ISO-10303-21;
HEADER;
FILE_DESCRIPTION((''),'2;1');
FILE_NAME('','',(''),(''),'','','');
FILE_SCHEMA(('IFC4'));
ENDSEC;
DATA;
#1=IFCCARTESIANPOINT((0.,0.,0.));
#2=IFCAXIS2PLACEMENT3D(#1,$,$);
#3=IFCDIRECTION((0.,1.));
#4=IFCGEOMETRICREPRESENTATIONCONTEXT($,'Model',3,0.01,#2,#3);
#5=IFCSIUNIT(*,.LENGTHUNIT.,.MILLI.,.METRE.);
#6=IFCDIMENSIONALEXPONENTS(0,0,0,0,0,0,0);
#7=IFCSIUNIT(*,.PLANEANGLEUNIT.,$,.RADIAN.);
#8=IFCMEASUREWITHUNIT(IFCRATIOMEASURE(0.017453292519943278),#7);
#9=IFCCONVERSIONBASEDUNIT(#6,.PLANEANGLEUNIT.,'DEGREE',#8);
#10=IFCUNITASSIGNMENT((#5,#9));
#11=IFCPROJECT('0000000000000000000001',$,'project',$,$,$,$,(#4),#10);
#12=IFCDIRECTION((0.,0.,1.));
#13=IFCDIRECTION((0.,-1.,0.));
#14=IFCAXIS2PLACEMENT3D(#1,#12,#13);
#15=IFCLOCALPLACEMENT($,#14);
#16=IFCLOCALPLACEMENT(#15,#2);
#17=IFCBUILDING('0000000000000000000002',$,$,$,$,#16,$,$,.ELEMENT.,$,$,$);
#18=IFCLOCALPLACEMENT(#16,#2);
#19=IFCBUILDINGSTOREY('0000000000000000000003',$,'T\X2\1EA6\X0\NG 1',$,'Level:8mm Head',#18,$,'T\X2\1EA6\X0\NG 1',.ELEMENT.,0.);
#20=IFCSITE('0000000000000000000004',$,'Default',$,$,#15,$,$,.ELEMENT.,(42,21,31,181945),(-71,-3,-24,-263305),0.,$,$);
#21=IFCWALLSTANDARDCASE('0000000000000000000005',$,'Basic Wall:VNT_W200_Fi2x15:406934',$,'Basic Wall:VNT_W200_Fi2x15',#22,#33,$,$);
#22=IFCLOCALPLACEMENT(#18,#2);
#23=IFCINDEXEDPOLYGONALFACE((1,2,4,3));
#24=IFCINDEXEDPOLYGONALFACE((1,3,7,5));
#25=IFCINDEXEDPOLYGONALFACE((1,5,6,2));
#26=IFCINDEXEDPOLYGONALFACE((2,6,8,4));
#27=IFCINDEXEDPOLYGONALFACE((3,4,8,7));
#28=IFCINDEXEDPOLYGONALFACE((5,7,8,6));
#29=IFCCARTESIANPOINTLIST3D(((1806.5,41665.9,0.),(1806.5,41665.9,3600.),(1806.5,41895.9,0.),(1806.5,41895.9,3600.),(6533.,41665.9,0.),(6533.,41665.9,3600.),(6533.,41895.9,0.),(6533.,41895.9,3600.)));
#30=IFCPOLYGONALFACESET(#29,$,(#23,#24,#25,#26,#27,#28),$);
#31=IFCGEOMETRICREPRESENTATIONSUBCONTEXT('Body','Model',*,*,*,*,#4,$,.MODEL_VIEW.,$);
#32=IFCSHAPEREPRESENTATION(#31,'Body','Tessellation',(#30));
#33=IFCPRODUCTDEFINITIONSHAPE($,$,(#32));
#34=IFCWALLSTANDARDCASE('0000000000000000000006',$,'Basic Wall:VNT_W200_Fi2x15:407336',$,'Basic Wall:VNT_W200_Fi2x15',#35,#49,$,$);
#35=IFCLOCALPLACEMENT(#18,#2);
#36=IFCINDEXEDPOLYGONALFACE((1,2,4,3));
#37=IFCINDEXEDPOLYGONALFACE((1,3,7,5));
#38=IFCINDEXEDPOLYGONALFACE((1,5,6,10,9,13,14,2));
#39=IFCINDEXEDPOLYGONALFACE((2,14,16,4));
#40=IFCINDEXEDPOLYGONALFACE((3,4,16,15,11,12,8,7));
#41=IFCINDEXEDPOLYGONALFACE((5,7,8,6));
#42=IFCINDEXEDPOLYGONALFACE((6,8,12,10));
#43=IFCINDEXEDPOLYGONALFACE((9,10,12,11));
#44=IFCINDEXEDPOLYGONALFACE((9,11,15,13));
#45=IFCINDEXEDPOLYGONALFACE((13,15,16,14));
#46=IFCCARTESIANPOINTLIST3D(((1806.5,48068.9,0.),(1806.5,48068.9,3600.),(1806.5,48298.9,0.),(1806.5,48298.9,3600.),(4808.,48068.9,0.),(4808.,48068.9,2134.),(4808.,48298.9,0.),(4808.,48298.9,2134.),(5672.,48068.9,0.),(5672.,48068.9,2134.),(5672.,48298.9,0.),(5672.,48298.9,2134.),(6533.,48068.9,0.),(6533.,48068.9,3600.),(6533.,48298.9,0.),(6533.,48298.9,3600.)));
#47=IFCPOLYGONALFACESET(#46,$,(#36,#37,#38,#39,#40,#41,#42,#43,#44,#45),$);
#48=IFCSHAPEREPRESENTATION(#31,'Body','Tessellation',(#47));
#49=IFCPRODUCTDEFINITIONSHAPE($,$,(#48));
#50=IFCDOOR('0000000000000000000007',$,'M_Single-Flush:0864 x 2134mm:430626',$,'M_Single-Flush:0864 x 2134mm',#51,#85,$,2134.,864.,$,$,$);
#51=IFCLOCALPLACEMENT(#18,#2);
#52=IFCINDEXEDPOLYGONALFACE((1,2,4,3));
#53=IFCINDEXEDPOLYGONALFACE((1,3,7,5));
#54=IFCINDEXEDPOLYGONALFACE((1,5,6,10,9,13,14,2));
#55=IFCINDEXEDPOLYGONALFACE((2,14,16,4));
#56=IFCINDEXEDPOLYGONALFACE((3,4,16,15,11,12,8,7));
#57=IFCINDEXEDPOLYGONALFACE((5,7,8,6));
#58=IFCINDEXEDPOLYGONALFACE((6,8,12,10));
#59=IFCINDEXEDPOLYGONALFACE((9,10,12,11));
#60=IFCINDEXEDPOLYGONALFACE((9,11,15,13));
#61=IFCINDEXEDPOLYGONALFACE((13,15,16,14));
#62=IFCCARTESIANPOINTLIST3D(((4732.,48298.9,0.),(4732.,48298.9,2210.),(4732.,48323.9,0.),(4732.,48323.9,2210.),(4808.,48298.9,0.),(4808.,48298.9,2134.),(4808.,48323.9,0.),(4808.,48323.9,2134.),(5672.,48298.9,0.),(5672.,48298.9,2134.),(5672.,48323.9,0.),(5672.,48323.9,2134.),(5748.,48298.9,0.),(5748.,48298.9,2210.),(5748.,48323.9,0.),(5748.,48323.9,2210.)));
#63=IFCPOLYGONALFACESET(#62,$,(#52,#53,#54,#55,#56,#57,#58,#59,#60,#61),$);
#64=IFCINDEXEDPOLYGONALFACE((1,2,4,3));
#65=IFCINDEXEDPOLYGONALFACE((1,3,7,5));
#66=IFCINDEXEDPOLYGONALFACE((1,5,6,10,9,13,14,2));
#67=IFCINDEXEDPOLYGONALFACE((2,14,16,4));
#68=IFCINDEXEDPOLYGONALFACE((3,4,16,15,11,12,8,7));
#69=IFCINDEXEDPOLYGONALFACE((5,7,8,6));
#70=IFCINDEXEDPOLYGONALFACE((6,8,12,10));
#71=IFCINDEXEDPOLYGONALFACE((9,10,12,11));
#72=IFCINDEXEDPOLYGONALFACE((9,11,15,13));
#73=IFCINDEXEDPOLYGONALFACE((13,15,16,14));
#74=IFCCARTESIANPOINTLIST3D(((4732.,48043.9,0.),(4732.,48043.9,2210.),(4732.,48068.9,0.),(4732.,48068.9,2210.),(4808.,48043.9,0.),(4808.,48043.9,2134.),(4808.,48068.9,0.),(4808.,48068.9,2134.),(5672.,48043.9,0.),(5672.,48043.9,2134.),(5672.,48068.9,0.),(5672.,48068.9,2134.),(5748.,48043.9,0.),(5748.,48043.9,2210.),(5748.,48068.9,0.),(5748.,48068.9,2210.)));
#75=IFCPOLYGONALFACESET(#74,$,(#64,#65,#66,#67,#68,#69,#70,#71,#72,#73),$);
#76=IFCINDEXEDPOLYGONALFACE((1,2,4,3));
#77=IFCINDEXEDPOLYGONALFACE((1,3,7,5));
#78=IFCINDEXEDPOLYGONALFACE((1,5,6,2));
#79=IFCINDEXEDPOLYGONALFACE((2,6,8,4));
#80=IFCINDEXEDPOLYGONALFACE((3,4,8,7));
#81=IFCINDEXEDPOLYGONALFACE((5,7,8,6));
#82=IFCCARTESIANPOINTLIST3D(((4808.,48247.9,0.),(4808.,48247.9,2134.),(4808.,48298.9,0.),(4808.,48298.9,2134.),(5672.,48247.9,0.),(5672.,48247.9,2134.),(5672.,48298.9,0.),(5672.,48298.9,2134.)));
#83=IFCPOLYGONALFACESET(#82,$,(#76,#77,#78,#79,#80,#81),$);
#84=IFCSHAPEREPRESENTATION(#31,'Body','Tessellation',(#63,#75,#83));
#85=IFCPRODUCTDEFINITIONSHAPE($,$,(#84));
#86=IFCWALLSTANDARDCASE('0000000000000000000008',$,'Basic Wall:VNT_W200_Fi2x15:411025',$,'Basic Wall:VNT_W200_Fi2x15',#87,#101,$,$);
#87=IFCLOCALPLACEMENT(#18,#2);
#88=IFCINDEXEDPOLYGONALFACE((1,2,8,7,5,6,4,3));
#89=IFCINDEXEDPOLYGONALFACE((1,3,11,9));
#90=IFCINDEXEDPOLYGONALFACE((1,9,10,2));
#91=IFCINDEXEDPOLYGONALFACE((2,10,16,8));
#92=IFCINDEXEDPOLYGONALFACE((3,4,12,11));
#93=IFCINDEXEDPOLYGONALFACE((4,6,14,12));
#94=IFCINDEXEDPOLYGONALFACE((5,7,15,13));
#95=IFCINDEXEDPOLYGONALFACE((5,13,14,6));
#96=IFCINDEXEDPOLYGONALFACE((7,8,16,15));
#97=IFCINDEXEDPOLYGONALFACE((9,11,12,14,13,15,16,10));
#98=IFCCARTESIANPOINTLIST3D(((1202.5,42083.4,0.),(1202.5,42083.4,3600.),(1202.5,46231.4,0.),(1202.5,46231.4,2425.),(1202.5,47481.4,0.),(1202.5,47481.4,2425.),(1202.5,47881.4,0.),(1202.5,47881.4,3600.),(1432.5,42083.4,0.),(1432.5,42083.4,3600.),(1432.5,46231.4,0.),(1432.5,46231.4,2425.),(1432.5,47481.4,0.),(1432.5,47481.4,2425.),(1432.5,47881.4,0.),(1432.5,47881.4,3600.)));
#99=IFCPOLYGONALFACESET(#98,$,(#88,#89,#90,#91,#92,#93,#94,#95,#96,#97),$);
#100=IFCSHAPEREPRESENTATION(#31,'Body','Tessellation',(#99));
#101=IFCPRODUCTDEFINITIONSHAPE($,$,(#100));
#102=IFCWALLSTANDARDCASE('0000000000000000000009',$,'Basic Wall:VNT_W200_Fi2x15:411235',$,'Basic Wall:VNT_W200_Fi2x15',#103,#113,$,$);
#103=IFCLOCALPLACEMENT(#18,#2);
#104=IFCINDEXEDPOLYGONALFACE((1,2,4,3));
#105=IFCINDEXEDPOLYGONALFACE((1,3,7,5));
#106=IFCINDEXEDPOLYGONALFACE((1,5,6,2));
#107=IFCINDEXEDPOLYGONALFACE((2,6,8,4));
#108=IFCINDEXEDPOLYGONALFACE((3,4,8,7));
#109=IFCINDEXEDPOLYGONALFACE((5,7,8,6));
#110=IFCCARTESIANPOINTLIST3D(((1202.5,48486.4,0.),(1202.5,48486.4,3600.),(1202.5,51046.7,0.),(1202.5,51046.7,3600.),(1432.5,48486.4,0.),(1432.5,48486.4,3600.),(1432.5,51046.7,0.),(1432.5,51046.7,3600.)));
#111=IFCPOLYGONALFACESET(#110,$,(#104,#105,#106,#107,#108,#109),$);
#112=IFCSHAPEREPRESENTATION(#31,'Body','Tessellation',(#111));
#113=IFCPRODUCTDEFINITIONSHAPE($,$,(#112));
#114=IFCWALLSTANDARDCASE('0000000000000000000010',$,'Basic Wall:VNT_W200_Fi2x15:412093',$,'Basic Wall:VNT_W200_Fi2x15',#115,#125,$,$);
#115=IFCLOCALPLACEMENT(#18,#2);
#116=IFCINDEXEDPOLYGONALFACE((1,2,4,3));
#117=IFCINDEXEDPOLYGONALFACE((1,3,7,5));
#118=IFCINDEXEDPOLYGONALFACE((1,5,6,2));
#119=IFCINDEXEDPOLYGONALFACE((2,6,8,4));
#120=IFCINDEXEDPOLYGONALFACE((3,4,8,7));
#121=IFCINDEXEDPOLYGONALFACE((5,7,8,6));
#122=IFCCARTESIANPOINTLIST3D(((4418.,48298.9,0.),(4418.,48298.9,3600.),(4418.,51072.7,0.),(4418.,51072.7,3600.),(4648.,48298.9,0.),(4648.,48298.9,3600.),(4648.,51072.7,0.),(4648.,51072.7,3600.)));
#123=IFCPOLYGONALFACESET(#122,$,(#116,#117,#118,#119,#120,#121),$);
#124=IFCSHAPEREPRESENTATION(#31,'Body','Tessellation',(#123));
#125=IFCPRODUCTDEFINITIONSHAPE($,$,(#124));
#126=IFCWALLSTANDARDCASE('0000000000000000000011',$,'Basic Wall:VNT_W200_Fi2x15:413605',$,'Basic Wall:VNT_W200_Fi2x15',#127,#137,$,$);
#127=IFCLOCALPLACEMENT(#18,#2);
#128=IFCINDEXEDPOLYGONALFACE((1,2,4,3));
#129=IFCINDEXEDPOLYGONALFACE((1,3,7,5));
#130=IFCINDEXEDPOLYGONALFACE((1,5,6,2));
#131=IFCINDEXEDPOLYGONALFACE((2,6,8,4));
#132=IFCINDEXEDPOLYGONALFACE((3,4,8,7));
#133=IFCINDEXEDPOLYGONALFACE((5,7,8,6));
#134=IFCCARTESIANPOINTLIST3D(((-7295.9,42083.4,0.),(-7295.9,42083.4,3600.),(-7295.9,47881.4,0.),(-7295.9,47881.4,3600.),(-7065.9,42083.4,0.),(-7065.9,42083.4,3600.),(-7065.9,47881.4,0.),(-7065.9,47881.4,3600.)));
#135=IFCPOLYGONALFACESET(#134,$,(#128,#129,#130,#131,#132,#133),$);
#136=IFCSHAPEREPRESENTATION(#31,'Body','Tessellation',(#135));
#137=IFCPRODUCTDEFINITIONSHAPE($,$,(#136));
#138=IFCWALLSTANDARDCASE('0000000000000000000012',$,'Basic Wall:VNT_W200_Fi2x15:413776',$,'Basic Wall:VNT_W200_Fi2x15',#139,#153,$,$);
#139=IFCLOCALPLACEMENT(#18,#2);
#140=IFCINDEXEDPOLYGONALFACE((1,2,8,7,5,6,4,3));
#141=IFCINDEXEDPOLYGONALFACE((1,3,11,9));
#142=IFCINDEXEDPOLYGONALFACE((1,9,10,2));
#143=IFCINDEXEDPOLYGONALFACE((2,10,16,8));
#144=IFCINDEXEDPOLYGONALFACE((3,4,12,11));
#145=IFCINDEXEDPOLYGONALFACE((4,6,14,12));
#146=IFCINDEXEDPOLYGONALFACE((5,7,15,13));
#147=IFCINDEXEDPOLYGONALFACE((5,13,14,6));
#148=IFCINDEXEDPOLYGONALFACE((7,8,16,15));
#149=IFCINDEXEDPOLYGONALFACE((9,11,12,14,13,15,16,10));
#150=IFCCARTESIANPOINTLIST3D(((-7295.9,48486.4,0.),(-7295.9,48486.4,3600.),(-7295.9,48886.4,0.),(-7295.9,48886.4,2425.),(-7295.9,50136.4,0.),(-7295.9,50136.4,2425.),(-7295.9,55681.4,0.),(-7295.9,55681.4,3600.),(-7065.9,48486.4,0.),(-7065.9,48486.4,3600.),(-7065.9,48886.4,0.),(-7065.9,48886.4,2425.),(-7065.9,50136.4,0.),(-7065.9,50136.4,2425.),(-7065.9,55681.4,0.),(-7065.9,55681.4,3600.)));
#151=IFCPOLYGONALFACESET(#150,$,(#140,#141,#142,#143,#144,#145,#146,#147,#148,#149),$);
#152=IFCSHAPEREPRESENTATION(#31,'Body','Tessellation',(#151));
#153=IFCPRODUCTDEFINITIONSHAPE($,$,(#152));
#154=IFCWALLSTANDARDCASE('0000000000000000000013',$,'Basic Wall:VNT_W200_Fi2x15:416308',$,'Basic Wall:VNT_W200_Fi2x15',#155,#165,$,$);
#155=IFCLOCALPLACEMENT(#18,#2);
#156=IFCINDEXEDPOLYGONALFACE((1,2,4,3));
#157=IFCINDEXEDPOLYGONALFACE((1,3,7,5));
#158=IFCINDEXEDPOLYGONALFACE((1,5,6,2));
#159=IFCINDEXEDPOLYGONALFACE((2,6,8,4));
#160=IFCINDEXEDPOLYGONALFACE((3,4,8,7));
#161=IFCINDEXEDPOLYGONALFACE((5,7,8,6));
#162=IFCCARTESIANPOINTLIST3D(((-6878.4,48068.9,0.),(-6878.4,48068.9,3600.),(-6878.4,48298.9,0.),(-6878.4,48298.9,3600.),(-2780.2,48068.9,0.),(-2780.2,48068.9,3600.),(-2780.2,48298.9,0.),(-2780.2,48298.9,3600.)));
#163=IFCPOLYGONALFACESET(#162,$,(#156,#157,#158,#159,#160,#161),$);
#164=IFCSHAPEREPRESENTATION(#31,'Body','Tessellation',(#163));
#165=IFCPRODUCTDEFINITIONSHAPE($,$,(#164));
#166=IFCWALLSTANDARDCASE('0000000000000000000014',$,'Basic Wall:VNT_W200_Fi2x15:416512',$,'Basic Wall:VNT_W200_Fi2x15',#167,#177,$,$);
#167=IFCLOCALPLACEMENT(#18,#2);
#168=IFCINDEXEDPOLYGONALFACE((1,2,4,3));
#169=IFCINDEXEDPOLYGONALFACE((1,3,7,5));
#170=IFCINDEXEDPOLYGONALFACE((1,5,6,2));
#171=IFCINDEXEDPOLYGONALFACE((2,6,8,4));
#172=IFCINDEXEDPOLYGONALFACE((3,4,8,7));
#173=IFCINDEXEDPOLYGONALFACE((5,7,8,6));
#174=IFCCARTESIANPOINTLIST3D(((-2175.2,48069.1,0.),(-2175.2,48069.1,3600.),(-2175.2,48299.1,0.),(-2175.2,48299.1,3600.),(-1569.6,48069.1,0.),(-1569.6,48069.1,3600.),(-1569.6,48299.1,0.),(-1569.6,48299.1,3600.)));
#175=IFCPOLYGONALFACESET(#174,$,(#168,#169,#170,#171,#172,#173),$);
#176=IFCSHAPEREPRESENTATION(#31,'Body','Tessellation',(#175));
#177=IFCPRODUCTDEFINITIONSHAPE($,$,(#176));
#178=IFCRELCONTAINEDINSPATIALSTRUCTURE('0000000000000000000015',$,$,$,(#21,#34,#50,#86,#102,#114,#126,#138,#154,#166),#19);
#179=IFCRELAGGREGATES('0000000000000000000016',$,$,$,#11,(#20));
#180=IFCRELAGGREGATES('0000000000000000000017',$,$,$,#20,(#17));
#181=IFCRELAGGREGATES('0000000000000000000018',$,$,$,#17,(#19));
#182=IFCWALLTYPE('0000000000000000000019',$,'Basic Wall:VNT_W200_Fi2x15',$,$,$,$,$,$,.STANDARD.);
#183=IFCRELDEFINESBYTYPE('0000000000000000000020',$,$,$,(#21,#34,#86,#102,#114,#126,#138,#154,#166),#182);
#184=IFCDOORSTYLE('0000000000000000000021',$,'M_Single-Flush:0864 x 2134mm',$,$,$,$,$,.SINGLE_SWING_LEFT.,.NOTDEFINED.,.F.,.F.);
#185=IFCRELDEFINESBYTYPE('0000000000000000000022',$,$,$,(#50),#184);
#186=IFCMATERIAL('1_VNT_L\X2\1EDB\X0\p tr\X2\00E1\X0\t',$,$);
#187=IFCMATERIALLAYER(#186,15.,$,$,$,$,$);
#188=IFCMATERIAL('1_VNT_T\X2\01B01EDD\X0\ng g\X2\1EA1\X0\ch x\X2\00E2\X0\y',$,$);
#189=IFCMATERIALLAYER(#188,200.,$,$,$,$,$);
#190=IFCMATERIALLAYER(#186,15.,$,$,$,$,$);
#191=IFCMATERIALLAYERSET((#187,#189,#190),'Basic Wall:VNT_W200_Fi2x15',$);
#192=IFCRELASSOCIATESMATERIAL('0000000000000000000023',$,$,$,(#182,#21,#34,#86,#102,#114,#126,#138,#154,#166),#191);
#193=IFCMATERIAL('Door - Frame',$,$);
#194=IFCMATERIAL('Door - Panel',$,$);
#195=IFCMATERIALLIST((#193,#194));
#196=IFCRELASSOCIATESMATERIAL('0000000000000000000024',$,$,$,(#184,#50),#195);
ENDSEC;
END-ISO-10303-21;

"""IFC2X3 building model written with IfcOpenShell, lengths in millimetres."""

from ifc_helpers import new_model, entity, si_unit, converted_unit, direction, frame, frame_2d, origin, place, context, subcontext, project, spatial, polyline, rectangle, outline, extrude, source, transform, mapped, material, material_list, layer, layer_set, layer_usage, type_object, type_shapes, element, fill, save


model = new_model("IFC2X3")

# Units and contexts
model_context = context("Model", 3, precision=0.01, world=origin(), true_north=direction((0.0, 1.0)))
body_context = subcontext(model_context, "Body", "Model", "MODEL_VIEW")
ifc_project = project(units=[si_unit("LENGTHUNIT", "METRE", prefix="MILLI"), converted_unit("PLANEANGLEUNIT", "DEGREE", entity("IfcRatioMeasure", 0.017453292519943278), si_unit("PLANEANGLEUNIT", "RADIAN"), dimensions=[0, 0, 0, 0, 0, 0, 0])], contexts=[model_context])

# Site, building, storey
site_placement = place(None, frame((0.0, 0.0, 0.0), z_axis=(0.0, 0.0, 1.0), x_axis=(0.0, -1.0, 0.0)))
site = spatial("IfcSite", under=ifc_project, at=site_placement, Name="Default", CompositionType="ELEMENT", RefLatitude=(42, 21, 31, 181945), RefLongitude=(-71, -3, -24, -263305), RefElevation=0.0)
building_placement = place(site_placement, origin())
building = spatial("IfcBuilding", under=site, at=building_placement, CompositionType="ELEMENT")
storey_placement = place(building_placement, origin())
storey = spatial("IfcBuildingStorey", under=building, at=storey_placement, Name="TẦNG 1", ObjectType="Level:8mm Head", LongName="TẦNG 1", CompositionType="ELEMENT", Elevation=0.0)

# Wall
ifc_material_1 = material(Name="1_VNT_Lớp trát")
ifc_layer_1 = layer(ifc_material_1, 15.0)
ifc_material_2 = material(Name="1_VNT_Tường gạch xây")
ifc_layer_2 = layer(ifc_material_2, 200.0)
ifc_layer_3 = layer(ifc_material_1, 15.0)
ifc_layer_set_1 = layer_set([ifc_layer_1, ifc_layer_2, ifc_layer_3], Name="Basic Wall:VNT_W200_Fi2x15")
ifc_layer_usage_1 = layer_usage(ifc_layer_set_1, "AXIS2", "NEGATIVE", 115.0)
wall_type_1 = type_object("IfcWallType", Name="Basic Wall:VNT_W200_Fi2x15", PredefinedType="STANDARD", material=ifc_layer_set_1)
wall_1_placement = place(storey_placement, frame((1806.5, 41780.9, 0.0)))
element("IfcWallStandardCase", 1, at=wall_1_placement, inside=storey, type_object=wall_type_1, material=ifc_layer_usage_1, Name="Basic Wall:VNT_W200_Fi2x15:406934", ObjectType="Basic Wall:VNT_W200_Fi2x15", context=body_context, shape_type="SweptSolid", body=[
    extrude(rectangle(XDim=4726.6, YDim=230.0, at=frame_2d((2363.3, 0.0), x_axis=(-1.0, 0.0))), origin(), (0.0, 0.0, 1.0), 3600.0),
])

# Wall, opening, door
wall_2_placement = place(storey_placement, frame((6533.0, 48183.9, 0.0), z_axis=(0.0, 0.0, 1.0), x_axis=(-1.0, 0.0, 0.0)))
wall_2 = element("IfcWallStandardCase", 2, at=wall_2_placement, inside=storey, type_object=wall_type_1, material=ifc_layer_usage_1, Name="Basic Wall:VNT_W200_Fi2x15:407336", ObjectType="Basic Wall:VNT_W200_Fi2x15", context=body_context, shape_type="SweptSolid", body=[
    extrude(rectangle(XDim=4726.6, YDim=230.0, at=frame_2d((2363.3, 0.0), x_axis=(-1.0, 0.0))), origin(), (0.0, 0.0, 1.0), 3600.0),
])
opening_1_placement = place(wall_2_placement, frame((1725.0, 115.0, 0.0)))
opening_1 = element("IfcOpeningElement", 3, at=opening_1_placement, cuts=wall_2, ObjectType="Opening", context=body_context, shape_type="SweptSolid", body=[
    extrude(rectangle(XDim=864.0, YDim=2134.0, at=frame_2d((1067.0, 432.0), x_axis=(0.0, -1.0))), frame((0.0, 0.0, 0.0), z_axis=(0.0, -1.0, 0.0), x_axis=(0.0, 0.0, 1.0)), (0.0, 0.0, 1.0), 230.0),
])
ifc_material_3 = material(Name="Door - Frame")
ifc_material_4 = material(Name="Door - Panel")
ifc_material_list = material_list([ifc_material_3, ifc_material_4])
door_style_1 = type_object("IfcDoorStyle", Name="M_Single-Flush:0864 x 2134mm", ConstructionType="NOTDEFINED", OperationType="SINGLE_SWING_LEFT", ParameterTakesPrecedence=False, Sizeable=False, material=ifc_material_list)
shared_shape_1 = source(origin(), body_context, "Body", "SweptSolid", [
    extrude(outline(polyline([(-508.0, -1124.0), (508.0, -1124.0), (508.0, 1086.0), (432.0, 1086.0), (432.0, -1048.0), (-432.0, -1048.0), (-432.0, 1086.0), (-508.0, 1086.0), (-508.0, -1124.0)])), frame((432.0, 255.0, 1086.0), z_axis=(0.0, -1.0, 0.0), x_axis=(-1.0, 0.0, 0.0)), (0.0, 0.0, 1.0), 25.0),
    extrude(outline(polyline([(-1124.0, -508.0), (1086.0, -508.0), (1086.0, -432.0), (-1048.0, -432.0), (-1048.0, 432.0), (1086.0, 432.0), (1086.0, 508.0), (-1124.0, 508.0), (-1124.0, -508.0)])), frame((432.0, 0.0, 1086.0), z_axis=(0.0, -1.0, 0.0), x_axis=(0.0, 0.0, -1.0)), (0.0, 0.0, 1.0), 25.0),
    extrude(rectangle(XDim=864.0, YDim=51.0, at=frame_2d((0.0, 0.0), x_axis=(1.0, 0.0))), frame((432.0, 204.5, 0.0)), (0.0, 0.0, 1.0), 2134.0),
])
type_shapes(door_style_1, [shared_shape_1])
door_1_placement = place(opening_1_placement, frame((0.0, 0.0, 0.0), z_axis=(0.0, 0.0, 1.0), x_axis=(-1.0, 0.0, 0.0)))
door_1 = element("IfcDoor", 4, at=door_1_placement, inside=storey, type_object=door_style_1, material=ifc_material_list, Name="M_Single-Flush:0864 x 2134mm:430626", ObjectType="M_Single-Flush:0864 x 2134mm", OverallHeight=2134.0, OverallWidth=864.0, context=body_context, shape_type="MappedRepresentation", body=[
    mapped(shared_shape_1, transform((0.0, 0.0, 0.0), scale=1.0)),
])
fill(opening_1, door_1)

# Wall, opening
wall_3_placement = place(storey_placement, frame((1317.5, 47881.4, 0.0), z_axis=(0.0, 0.0, 1.0), x_axis=(0.0, -1.0, 0.0)))
wall_3 = element("IfcWallStandardCase", 5, at=wall_3_placement, inside=storey, type_object=wall_type_1, material=ifc_layer_usage_1, Name="Basic Wall:VNT_W200_Fi2x15:411025", ObjectType="Basic Wall:VNT_W200_Fi2x15", context=body_context, shape_type="SweptSolid", body=[
    extrude(rectangle(XDim=5798.0, YDim=230.0, at=frame_2d((2899.0, 0.0), x_axis=(-1.0, 0.0))), origin(), (0.0, 0.0, 1.0), 3600.0),
])
opening_2_placement = place(wall_3_placement, frame((400.0, -115.0, 0.0)))
element("IfcOpeningElement", 6, at=opening_2_placement, cuts=wall_3, ObjectType="Opening", context=body_context, shape_type="SweptSolid", body=[
    extrude(rectangle(XDim=2425.0, YDim=1250.0, at=frame_2d((1212.5, 625.0), x_axis=(1.0, 0.0))), frame((0.0, 0.0, 0.0), z_axis=(0.0, 1.0, 0.0), x_axis=(0.0, 0.0, 1.0)), (0.0, 0.0, 1.0), 230.0),
])

# Walls
wall_4_placement = place(storey_placement, frame((1317.5, 48486.4, 0.0), z_axis=(0.0, 0.0, 1.0), x_axis=(0.0, 1.0, 0.0)))
element("IfcWallStandardCase", 7, at=wall_4_placement, inside=storey, type_object=wall_type_1, material=ifc_layer_usage_1, Name="Basic Wall:VNT_W200_Fi2x15:411235", ObjectType="Basic Wall:VNT_W200_Fi2x15", context=body_context, shape_type="SweptSolid", body=[
    extrude(rectangle(XDim=2560.3, YDim=230.0, at=frame_2d((1280.1, 0.0), x_axis=(-1.0, 0.0))), origin(), (0.0, 0.0, 1.0), 3600.0),
])
wall_5_placement = place(storey_placement, frame((4533.0, 48298.9, 0.0), z_axis=(0.0, 0.0, 1.0), x_axis=(0.0, 1.0, 0.0)))
element("IfcWallStandardCase", 8, at=wall_5_placement, inside=storey, type_object=wall_type_1, material=ifc_layer_usage_1, Name="Basic Wall:VNT_W200_Fi2x15:412093", ObjectType="Basic Wall:VNT_W200_Fi2x15", context=body_context, shape_type="SweptSolid", body=[
    extrude(rectangle(XDim=2773.8, YDim=230.0, at=frame_2d((1386.9, 0.0), x_axis=(-1.0, 0.0))), origin(), (0.0, 0.0, 1.0), 3600.0),
])
wall_6_placement = place(storey_placement, frame((-7180.9, 42083.4, 0.0), z_axis=(0.0, 0.0, 1.0), x_axis=(0.0, 1.0, 0.0)))
element("IfcWallStandardCase", 9, at=wall_6_placement, inside=storey, type_object=wall_type_1, material=ifc_layer_usage_1, Name="Basic Wall:VNT_W200_Fi2x15:413605", ObjectType="Basic Wall:VNT_W200_Fi2x15", context=body_context, shape_type="SweptSolid", body=[
    extrude(rectangle(XDim=5798.0, YDim=230.0, at=frame_2d((2899.0, 0.0), x_axis=(-1.0, 0.0))), origin(), (0.0, 0.0, 1.0), 3600.0),
])

# Wall, opening
wall_7_placement = place(storey_placement, frame((-7180.9, 48486.4, 0.0), z_axis=(0.0, 0.0, 1.0), x_axis=(0.0, 1.0, 0.0)))
wall_7 = element("IfcWallStandardCase", 10, at=wall_7_placement, inside=storey, type_object=wall_type_1, material=ifc_layer_usage_1, Name="Basic Wall:VNT_W200_Fi2x15:413776", ObjectType="Basic Wall:VNT_W200_Fi2x15", context=body_context, shape_type="SweptSolid", body=[
    extrude(rectangle(XDim=7195.0, YDim=230.0, at=frame_2d((3597.5, 0.0), x_axis=(1.0, 0.0))), origin(), (0.0, 0.0, 1.0), 3600.0),
])
opening_3_placement = place(wall_7_placement, frame((400.0, -115.0, 0.0)))
element("IfcOpeningElement", 11, at=opening_3_placement, cuts=wall_7, ObjectType="Opening", context=body_context, shape_type="SweptSolid", body=[
    extrude(rectangle(XDim=2425.0, YDim=1250.0, at=frame_2d((1212.5, 625.0), x_axis=(1.0, 0.0))), frame((0.0, 0.0, 0.0), z_axis=(0.0, 1.0, 0.0), x_axis=(0.0, 0.0, 1.0)), (0.0, 0.0, 1.0), 230.0),
])

# Walls
wall_8_placement = place(storey_placement, frame((-6878.4, 48183.9, 0.0)))
element("IfcWallStandardCase", 12, at=wall_8_placement, inside=storey, type_object=wall_type_1, material=ifc_layer_usage_1, Name="Basic Wall:VNT_W200_Fi2x15:416308", ObjectType="Basic Wall:VNT_W200_Fi2x15", context=body_context, shape_type="SweptSolid", body=[
    extrude(rectangle(XDim=4098.3, YDim=230.0, at=frame_2d((2049.1, 0.0), x_axis=(-1.0, 0.0))), origin(), (0.0, 0.0, 1.0), 3600.0),
])
wall_9_placement = place(storey_placement, frame((-2175.2, 48184.1, 0.0)))
element("IfcWallStandardCase", 13, at=wall_9_placement, inside=storey, type_object=wall_type_1, material=ifc_layer_usage_1, Name="Basic Wall:VNT_W200_Fi2x15:416512", ObjectType="Basic Wall:VNT_W200_Fi2x15", context=body_context, shape_type="SweptSolid", body=[
    extrude(rectangle(XDim=605.6, YDim=230.0, at=frame_2d((302.8, 0.0), x_axis=(-1.0, 0.0))), origin(), (0.0, 0.0, 1.0), 3600.0),
])

save(model, "model.ifc")
